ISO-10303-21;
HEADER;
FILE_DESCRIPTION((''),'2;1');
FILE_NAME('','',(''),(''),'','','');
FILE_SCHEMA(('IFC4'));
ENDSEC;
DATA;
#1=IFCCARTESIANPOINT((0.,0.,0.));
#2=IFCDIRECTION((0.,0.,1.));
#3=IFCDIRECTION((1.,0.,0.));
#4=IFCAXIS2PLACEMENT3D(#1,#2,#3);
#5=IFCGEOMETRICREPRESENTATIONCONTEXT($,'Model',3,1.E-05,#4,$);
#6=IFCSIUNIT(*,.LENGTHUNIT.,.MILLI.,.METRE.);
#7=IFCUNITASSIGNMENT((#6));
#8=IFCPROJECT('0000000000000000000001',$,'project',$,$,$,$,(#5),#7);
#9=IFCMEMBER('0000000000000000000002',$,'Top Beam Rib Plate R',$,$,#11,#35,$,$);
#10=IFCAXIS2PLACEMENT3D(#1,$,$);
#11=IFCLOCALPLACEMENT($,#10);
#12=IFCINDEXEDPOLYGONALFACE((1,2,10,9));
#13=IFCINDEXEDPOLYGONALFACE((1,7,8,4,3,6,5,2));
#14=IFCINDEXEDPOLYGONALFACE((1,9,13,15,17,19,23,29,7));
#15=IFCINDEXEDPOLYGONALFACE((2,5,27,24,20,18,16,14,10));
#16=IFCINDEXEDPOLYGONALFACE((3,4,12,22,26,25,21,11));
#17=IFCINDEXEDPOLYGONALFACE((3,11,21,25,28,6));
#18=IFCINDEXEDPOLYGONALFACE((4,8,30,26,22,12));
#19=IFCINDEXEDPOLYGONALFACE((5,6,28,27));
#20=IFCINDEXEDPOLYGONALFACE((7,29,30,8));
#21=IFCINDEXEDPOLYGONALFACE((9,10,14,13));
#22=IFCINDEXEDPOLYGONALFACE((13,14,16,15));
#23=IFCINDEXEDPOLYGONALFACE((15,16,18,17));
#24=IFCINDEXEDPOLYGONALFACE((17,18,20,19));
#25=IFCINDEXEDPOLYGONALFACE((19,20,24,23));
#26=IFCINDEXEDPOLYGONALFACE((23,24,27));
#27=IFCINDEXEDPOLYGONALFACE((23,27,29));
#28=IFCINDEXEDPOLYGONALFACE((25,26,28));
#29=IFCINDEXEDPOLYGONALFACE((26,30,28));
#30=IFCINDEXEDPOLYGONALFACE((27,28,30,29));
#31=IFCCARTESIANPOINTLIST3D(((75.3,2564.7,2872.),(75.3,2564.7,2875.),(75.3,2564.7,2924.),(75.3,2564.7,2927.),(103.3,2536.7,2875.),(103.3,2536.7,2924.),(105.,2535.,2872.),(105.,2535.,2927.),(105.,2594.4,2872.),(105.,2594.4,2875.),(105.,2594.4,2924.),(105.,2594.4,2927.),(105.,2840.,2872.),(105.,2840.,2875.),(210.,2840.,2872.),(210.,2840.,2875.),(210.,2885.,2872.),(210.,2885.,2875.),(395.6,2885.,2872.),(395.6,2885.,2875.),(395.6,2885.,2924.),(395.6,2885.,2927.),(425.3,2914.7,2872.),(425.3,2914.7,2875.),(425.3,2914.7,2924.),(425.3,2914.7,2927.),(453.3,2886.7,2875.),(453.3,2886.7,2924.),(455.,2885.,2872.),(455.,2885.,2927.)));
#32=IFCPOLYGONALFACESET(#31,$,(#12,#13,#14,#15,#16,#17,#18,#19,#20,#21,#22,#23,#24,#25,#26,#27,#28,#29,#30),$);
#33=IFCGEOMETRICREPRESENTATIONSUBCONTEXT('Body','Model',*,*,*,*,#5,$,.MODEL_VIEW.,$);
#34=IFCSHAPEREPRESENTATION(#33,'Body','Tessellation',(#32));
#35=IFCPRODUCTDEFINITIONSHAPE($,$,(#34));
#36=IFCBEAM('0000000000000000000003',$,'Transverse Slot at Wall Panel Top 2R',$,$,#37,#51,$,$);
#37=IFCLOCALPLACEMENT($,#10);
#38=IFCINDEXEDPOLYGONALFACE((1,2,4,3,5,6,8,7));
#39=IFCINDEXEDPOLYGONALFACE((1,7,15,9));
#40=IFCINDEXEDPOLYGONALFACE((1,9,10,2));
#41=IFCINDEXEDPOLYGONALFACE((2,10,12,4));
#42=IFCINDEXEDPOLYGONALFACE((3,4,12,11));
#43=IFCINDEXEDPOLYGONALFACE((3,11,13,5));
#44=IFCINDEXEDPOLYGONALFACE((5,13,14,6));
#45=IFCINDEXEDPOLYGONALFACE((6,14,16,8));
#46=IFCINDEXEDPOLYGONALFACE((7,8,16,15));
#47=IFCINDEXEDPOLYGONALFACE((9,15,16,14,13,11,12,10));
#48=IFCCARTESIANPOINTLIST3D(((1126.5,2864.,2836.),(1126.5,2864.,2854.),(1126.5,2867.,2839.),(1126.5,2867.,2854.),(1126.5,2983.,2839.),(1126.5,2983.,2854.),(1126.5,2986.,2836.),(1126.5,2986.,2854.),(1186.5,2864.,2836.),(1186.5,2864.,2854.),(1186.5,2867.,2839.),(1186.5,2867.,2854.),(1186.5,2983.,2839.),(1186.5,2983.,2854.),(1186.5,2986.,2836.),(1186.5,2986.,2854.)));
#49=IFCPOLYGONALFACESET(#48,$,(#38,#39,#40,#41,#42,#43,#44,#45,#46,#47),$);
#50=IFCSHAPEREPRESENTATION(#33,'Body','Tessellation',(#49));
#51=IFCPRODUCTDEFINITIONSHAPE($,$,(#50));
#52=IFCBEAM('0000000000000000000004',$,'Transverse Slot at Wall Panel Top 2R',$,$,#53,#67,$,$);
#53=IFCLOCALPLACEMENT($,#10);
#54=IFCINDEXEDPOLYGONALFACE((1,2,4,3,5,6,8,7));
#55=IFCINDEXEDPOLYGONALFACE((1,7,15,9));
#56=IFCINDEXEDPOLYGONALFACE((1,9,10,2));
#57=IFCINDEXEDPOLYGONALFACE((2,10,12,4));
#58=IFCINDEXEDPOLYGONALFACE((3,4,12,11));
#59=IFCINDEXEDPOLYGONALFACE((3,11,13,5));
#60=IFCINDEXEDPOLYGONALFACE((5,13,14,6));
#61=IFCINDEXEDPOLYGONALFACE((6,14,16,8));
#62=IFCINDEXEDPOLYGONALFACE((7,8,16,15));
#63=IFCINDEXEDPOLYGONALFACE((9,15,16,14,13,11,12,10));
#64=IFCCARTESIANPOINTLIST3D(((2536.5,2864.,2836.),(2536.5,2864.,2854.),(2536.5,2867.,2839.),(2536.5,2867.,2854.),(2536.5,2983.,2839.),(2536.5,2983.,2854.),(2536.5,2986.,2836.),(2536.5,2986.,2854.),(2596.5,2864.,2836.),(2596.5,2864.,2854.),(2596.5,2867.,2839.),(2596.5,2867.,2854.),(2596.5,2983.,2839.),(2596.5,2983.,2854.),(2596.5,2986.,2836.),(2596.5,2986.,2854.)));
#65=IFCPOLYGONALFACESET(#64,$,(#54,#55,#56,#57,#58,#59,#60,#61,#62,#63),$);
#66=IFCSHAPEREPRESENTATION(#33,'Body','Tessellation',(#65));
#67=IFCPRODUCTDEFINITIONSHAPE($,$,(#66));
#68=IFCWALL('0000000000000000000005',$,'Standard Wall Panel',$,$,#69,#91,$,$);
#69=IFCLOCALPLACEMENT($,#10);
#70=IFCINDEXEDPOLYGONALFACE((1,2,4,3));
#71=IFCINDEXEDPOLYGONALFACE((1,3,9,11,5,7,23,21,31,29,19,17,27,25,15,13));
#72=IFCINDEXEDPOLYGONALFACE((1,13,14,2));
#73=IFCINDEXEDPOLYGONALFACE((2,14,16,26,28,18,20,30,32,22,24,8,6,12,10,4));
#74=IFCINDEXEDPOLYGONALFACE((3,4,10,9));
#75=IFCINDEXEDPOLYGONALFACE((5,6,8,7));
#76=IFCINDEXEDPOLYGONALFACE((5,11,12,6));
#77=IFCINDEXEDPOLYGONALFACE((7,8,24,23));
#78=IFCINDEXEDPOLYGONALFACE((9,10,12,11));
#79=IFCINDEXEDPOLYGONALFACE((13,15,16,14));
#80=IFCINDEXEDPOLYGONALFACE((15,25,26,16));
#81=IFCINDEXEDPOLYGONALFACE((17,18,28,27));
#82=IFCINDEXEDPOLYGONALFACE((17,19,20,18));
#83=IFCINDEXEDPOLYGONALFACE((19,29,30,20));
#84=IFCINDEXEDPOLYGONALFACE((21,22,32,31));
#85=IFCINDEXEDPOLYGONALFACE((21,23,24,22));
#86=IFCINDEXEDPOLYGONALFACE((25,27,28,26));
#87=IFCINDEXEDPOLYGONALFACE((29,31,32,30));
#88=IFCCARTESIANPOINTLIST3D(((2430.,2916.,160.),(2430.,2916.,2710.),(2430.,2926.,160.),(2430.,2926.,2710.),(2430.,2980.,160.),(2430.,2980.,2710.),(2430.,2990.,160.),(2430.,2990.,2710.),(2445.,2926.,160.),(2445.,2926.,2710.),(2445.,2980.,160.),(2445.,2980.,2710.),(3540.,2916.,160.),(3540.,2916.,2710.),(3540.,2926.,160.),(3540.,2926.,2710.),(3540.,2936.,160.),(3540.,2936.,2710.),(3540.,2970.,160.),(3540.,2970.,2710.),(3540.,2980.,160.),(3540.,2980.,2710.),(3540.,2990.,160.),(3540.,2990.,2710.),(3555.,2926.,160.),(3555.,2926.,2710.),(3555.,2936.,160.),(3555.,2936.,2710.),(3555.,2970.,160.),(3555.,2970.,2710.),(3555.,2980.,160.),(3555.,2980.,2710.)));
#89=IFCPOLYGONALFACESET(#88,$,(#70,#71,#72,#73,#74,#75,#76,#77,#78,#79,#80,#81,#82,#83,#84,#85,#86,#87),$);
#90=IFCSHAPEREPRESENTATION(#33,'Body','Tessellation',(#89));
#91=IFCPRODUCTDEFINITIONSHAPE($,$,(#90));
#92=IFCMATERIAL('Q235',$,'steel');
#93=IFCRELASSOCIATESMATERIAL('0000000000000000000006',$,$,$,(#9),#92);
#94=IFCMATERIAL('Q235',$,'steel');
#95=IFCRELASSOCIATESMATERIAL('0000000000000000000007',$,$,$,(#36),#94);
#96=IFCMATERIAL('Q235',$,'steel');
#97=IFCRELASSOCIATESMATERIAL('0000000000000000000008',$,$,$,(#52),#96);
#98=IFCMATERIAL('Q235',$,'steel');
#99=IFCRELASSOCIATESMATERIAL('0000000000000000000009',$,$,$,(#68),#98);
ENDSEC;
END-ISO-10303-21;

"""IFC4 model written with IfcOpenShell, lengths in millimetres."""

from ifc_helpers import new_model, si_unit, frame, origin_with_axes, place, context, subcontext, project, line, indexed_curve, outline, extrude, material, element, save


model = new_model("IFC4")

# Units and contexts
model_context = context("Model", 3, precision=1e-05, world=origin_with_axes())
body_context = subcontext(model_context, "Body", "Model", "MODEL_VIEW")
ifc_project = project(units=[si_unit("LENGTHUNIT", "METRE", prefix="MILLI")], contexts=[model_context])

# Member, openings
ifc_material_1 = material(Name="Q235", Category="steel")
member_1_placement = place(None, frame((210.0, 2840.0, 2872.0), z_axis=(0.0, 0.0, 1.0), x_axis=(1.0, 0.0, 0.0)))
member_1 = element("IfcMember", 1, at=member_1_placement, material=ifc_material_1, Name="Top Beam Rib Plate R", context=body_context, shape_type="SweptSolid", body=[
    extrude(outline(indexed_curve([(0.0, 0.0), (0.0, 45.0), (185.6, 45.0), (215.3, 74.7), (245.0, 45.0), (-105.0, -305.0), (-134.7, -275.3), (-105.0, -245.6), (-105.0, 0.0), (0.0, 0.0)], segments=[line(1, 2, 3, 4, 5, 6, 7, 8, 9, 10, 1)])), origin_with_axes(), (0.0, 0.0, 1.0), 55.0),
])
opening_1_placement = place(member_1_placement, frame((0.0, 0.0, 3.0), z_axis=(0.0, 0.0, 1.0), x_axis=(1.0, 0.0, 0.0)))
element("IfcOpeningElement", 2, at=opening_1_placement, cuts=member_1, context=body_context, shape_type="SweptSolid", body=[
    extrude(outline(indexed_curve([(0.0, 0.0), (0.0, 45.0), (185.6, 45.0), (-105.0, -245.6), (-105.0, 0.0), (0.0, 0.0)], segments=[line(1, 2, 3, 4, 5, 6, 1)])), origin_with_axes(), (0.0, 0.0, 1.0), 55.0),
])
opening_2_placement = place(member_1_placement, frame((0.0, 0.0, 3.0), z_axis=(0.0, 0.0, 1.0), x_axis=(1.0, 0.0, 0.0)))
element("IfcOpeningElement", 3, at=opening_2_placement, cuts=member_1, context=body_context, shape_type="SweptSolid", body=[
    extrude(outline(indexed_curve([(215.3, 74.7), (243.3, 46.7), (-106.7, -303.3), (-134.7, -275.3)], segments=[line(1, 2, 3, 4, 1)])), origin_with_axes(), (0.0, 0.0, 1.0), 49.0),
])

# Beams
ifc_material_2 = material(Name="Q235", Category="steel")
beam_1_placement = place(None, frame((1126.5, 2986.0, 2836.0), z_axis=(1.0, 0.0, 0.0), x_axis=(0.0, 0.0, 1.0)))
element("IfcBeam", 4, at=beam_1_placement, material=ifc_material_2, Name="Transverse Slot at Wall Panel Top 2R", context=body_context, shape_type="SweptSolid", body=[
    extrude(outline(indexed_curve([(0.0, 0.0), (0.0, 122.0), (18.0, 122.0), (18.0, 119.0), (3.0, 119.0), (3.0, 3.0), (18.0, 3.0), (18.0, 0.0), (0.0, 0.0)], segments=[line(1, 2, 3, 4, 5, 6, 7, 8, 9, 1)])), origin_with_axes(), (0.0, 0.0, 1.0), 60.0),
])
ifc_material_3 = material(Name="Q235", Category="steel")
beam_2_placement = place(None, frame((2536.5, 2986.0, 2836.0), z_axis=(1.0, 0.0, 0.0), x_axis=(0.0, 0.0, 1.0)))
element("IfcBeam", 5, at=beam_2_placement, material=ifc_material_3, Name="Transverse Slot at Wall Panel Top 2R", context=body_context, shape_type="SweptSolid", body=[
    extrude(outline(indexed_curve([(0.0, 0.0), (0.0, 122.0), (18.0, 122.0), (18.0, 119.0), (3.0, 119.0), (3.0, 3.0), (18.0, 3.0), (18.0, 0.0), (0.0, 0.0)], segments=[line(1, 2, 3, 4, 5, 6, 7, 8, 9, 1)])), origin_with_axes(), (0.0, 0.0, 1.0), 60.0),
])

# Wall
ifc_material_4 = material(Name="Q235", Category="steel")
wall_placement = place(None, frame((2430.0, 2916.0, 160.0), z_axis=(0.0, 0.0, 1.0), x_axis=(1.0, 0.0, 0.0)))
element("IfcWall", 6, at=wall_placement, material=ifc_material_4, Name="Standard Wall Panel", context=body_context, shape_type="SweptSolid", body=[
    extrude(outline(indexed_curve([(0.0, 0.0), (0.0, 10.0), (15.0, 10.0), (15.0, 64.0), (0.0, 64.0), (0.0, 74.0), (1110.0, 74.0), (1110.0, 64.0), (1125.0, 64.0), (1125.0, 54.0), (1125.0, 54.0), (1110.0, 54.0), (1110.0, 20.0), (1125.0, 20.0), (1125.0, 10.0), (1110.0, 10.0), (1110.0, 0.0), (0.0, 0.0)], segments=[line(1, 2, 3, 4, 5, 6, 7, 8, 9, 10, 11, 12, 13, 14, 15, 16, 17, 18, 1)])), origin_with_axes(), (0.0, 0.0, 1.0), 2550.0),
])

save(model, "model.ifc")
